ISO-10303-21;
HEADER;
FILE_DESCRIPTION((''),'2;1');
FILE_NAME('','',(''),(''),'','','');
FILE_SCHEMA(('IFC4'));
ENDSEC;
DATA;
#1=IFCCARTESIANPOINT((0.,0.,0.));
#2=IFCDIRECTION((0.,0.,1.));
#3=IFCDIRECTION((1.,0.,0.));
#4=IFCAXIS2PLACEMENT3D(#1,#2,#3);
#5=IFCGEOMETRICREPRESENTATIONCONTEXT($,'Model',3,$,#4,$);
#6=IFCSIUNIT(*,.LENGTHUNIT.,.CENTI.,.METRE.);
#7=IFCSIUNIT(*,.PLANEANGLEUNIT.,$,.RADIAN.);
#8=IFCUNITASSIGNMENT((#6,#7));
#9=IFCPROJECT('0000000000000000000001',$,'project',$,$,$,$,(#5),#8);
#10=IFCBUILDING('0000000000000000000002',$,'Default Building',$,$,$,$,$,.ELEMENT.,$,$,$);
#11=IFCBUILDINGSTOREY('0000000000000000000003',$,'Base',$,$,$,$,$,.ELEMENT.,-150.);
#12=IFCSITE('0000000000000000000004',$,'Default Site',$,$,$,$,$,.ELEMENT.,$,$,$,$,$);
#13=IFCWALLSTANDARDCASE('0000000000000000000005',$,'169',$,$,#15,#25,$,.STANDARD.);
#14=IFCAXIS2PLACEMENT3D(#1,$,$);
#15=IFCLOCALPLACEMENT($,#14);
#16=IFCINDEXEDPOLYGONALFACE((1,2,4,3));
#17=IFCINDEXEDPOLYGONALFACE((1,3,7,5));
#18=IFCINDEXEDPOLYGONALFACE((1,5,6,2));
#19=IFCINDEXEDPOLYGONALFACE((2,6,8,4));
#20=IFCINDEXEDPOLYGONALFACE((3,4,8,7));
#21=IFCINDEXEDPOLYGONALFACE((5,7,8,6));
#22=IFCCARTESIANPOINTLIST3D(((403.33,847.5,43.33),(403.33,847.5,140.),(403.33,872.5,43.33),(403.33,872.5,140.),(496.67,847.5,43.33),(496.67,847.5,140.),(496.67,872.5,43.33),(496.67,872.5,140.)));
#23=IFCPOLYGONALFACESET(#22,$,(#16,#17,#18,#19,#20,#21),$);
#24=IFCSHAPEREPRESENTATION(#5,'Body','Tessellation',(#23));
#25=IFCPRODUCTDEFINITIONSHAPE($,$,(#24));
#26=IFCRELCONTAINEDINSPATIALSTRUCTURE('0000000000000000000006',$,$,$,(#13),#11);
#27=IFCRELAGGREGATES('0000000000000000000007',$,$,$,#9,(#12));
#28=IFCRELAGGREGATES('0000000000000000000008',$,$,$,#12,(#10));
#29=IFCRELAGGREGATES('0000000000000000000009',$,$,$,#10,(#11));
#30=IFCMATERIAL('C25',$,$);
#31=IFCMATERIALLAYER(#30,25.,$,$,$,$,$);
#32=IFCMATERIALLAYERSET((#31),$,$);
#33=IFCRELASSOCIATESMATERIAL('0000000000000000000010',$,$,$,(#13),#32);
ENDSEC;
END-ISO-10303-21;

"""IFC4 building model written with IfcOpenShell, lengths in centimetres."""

from ifc_helpers import new_model, si_unit, frame, origin_with_axes, origin_2d_with_axis, place, context, project, spatial, rectangle, extrude, material, layer, layer_set, layer_usage, element, save


model = new_model("IFC4")

# Units and contexts
model_context = context("Model", 3, world=origin_with_axes())
ifc_project = project(units=[si_unit("LENGTHUNIT", "METRE", prefix="CENTI"), si_unit("PLANEANGLEUNIT", "RADIAN")], contexts=[model_context])

# Site, building, storey
site = spatial("IfcSite", under=ifc_project, Name="Default Site", CompositionType="ELEMENT")
building = spatial("IfcBuilding", under=site, Name="Default Building", CompositionType="ELEMENT")
storey = spatial("IfcBuildingStorey", under=building, Name="Base", CompositionType="ELEMENT", Elevation=-150.0)

# Shared definitions
ifc_material = material(Name="C25")

# Wall
ifc_layer_1 = layer(ifc_material, 25.0)
ifc_layer_set_1 = layer_set([ifc_layer_1])
ifc_layer_usage_1 = layer_usage(ifc_layer_set_1, "AXIS2", "POSITIVE", -25.0)
wall_1_placement = place(None, frame((450.0, 860.0, 43.33), z_axis=(0.0, 0.0, 1.0), x_axis=(1.0, 0.0, 0.0)))
element("IfcWallStandardCase", 1, at=wall_1_placement, inside=storey, material=ifc_layer_usage_1, Name="169", PredefinedType="STANDARD", context=model_context, shape_type="SweptSolid", body=[
    extrude(rectangle(XDim=93.33, YDim=25.0, at=origin_2d_with_axis()), origin_with_axes(), (0.0, 0.0, 1.0), 96.67),
])

save(model, "model.ifc")
